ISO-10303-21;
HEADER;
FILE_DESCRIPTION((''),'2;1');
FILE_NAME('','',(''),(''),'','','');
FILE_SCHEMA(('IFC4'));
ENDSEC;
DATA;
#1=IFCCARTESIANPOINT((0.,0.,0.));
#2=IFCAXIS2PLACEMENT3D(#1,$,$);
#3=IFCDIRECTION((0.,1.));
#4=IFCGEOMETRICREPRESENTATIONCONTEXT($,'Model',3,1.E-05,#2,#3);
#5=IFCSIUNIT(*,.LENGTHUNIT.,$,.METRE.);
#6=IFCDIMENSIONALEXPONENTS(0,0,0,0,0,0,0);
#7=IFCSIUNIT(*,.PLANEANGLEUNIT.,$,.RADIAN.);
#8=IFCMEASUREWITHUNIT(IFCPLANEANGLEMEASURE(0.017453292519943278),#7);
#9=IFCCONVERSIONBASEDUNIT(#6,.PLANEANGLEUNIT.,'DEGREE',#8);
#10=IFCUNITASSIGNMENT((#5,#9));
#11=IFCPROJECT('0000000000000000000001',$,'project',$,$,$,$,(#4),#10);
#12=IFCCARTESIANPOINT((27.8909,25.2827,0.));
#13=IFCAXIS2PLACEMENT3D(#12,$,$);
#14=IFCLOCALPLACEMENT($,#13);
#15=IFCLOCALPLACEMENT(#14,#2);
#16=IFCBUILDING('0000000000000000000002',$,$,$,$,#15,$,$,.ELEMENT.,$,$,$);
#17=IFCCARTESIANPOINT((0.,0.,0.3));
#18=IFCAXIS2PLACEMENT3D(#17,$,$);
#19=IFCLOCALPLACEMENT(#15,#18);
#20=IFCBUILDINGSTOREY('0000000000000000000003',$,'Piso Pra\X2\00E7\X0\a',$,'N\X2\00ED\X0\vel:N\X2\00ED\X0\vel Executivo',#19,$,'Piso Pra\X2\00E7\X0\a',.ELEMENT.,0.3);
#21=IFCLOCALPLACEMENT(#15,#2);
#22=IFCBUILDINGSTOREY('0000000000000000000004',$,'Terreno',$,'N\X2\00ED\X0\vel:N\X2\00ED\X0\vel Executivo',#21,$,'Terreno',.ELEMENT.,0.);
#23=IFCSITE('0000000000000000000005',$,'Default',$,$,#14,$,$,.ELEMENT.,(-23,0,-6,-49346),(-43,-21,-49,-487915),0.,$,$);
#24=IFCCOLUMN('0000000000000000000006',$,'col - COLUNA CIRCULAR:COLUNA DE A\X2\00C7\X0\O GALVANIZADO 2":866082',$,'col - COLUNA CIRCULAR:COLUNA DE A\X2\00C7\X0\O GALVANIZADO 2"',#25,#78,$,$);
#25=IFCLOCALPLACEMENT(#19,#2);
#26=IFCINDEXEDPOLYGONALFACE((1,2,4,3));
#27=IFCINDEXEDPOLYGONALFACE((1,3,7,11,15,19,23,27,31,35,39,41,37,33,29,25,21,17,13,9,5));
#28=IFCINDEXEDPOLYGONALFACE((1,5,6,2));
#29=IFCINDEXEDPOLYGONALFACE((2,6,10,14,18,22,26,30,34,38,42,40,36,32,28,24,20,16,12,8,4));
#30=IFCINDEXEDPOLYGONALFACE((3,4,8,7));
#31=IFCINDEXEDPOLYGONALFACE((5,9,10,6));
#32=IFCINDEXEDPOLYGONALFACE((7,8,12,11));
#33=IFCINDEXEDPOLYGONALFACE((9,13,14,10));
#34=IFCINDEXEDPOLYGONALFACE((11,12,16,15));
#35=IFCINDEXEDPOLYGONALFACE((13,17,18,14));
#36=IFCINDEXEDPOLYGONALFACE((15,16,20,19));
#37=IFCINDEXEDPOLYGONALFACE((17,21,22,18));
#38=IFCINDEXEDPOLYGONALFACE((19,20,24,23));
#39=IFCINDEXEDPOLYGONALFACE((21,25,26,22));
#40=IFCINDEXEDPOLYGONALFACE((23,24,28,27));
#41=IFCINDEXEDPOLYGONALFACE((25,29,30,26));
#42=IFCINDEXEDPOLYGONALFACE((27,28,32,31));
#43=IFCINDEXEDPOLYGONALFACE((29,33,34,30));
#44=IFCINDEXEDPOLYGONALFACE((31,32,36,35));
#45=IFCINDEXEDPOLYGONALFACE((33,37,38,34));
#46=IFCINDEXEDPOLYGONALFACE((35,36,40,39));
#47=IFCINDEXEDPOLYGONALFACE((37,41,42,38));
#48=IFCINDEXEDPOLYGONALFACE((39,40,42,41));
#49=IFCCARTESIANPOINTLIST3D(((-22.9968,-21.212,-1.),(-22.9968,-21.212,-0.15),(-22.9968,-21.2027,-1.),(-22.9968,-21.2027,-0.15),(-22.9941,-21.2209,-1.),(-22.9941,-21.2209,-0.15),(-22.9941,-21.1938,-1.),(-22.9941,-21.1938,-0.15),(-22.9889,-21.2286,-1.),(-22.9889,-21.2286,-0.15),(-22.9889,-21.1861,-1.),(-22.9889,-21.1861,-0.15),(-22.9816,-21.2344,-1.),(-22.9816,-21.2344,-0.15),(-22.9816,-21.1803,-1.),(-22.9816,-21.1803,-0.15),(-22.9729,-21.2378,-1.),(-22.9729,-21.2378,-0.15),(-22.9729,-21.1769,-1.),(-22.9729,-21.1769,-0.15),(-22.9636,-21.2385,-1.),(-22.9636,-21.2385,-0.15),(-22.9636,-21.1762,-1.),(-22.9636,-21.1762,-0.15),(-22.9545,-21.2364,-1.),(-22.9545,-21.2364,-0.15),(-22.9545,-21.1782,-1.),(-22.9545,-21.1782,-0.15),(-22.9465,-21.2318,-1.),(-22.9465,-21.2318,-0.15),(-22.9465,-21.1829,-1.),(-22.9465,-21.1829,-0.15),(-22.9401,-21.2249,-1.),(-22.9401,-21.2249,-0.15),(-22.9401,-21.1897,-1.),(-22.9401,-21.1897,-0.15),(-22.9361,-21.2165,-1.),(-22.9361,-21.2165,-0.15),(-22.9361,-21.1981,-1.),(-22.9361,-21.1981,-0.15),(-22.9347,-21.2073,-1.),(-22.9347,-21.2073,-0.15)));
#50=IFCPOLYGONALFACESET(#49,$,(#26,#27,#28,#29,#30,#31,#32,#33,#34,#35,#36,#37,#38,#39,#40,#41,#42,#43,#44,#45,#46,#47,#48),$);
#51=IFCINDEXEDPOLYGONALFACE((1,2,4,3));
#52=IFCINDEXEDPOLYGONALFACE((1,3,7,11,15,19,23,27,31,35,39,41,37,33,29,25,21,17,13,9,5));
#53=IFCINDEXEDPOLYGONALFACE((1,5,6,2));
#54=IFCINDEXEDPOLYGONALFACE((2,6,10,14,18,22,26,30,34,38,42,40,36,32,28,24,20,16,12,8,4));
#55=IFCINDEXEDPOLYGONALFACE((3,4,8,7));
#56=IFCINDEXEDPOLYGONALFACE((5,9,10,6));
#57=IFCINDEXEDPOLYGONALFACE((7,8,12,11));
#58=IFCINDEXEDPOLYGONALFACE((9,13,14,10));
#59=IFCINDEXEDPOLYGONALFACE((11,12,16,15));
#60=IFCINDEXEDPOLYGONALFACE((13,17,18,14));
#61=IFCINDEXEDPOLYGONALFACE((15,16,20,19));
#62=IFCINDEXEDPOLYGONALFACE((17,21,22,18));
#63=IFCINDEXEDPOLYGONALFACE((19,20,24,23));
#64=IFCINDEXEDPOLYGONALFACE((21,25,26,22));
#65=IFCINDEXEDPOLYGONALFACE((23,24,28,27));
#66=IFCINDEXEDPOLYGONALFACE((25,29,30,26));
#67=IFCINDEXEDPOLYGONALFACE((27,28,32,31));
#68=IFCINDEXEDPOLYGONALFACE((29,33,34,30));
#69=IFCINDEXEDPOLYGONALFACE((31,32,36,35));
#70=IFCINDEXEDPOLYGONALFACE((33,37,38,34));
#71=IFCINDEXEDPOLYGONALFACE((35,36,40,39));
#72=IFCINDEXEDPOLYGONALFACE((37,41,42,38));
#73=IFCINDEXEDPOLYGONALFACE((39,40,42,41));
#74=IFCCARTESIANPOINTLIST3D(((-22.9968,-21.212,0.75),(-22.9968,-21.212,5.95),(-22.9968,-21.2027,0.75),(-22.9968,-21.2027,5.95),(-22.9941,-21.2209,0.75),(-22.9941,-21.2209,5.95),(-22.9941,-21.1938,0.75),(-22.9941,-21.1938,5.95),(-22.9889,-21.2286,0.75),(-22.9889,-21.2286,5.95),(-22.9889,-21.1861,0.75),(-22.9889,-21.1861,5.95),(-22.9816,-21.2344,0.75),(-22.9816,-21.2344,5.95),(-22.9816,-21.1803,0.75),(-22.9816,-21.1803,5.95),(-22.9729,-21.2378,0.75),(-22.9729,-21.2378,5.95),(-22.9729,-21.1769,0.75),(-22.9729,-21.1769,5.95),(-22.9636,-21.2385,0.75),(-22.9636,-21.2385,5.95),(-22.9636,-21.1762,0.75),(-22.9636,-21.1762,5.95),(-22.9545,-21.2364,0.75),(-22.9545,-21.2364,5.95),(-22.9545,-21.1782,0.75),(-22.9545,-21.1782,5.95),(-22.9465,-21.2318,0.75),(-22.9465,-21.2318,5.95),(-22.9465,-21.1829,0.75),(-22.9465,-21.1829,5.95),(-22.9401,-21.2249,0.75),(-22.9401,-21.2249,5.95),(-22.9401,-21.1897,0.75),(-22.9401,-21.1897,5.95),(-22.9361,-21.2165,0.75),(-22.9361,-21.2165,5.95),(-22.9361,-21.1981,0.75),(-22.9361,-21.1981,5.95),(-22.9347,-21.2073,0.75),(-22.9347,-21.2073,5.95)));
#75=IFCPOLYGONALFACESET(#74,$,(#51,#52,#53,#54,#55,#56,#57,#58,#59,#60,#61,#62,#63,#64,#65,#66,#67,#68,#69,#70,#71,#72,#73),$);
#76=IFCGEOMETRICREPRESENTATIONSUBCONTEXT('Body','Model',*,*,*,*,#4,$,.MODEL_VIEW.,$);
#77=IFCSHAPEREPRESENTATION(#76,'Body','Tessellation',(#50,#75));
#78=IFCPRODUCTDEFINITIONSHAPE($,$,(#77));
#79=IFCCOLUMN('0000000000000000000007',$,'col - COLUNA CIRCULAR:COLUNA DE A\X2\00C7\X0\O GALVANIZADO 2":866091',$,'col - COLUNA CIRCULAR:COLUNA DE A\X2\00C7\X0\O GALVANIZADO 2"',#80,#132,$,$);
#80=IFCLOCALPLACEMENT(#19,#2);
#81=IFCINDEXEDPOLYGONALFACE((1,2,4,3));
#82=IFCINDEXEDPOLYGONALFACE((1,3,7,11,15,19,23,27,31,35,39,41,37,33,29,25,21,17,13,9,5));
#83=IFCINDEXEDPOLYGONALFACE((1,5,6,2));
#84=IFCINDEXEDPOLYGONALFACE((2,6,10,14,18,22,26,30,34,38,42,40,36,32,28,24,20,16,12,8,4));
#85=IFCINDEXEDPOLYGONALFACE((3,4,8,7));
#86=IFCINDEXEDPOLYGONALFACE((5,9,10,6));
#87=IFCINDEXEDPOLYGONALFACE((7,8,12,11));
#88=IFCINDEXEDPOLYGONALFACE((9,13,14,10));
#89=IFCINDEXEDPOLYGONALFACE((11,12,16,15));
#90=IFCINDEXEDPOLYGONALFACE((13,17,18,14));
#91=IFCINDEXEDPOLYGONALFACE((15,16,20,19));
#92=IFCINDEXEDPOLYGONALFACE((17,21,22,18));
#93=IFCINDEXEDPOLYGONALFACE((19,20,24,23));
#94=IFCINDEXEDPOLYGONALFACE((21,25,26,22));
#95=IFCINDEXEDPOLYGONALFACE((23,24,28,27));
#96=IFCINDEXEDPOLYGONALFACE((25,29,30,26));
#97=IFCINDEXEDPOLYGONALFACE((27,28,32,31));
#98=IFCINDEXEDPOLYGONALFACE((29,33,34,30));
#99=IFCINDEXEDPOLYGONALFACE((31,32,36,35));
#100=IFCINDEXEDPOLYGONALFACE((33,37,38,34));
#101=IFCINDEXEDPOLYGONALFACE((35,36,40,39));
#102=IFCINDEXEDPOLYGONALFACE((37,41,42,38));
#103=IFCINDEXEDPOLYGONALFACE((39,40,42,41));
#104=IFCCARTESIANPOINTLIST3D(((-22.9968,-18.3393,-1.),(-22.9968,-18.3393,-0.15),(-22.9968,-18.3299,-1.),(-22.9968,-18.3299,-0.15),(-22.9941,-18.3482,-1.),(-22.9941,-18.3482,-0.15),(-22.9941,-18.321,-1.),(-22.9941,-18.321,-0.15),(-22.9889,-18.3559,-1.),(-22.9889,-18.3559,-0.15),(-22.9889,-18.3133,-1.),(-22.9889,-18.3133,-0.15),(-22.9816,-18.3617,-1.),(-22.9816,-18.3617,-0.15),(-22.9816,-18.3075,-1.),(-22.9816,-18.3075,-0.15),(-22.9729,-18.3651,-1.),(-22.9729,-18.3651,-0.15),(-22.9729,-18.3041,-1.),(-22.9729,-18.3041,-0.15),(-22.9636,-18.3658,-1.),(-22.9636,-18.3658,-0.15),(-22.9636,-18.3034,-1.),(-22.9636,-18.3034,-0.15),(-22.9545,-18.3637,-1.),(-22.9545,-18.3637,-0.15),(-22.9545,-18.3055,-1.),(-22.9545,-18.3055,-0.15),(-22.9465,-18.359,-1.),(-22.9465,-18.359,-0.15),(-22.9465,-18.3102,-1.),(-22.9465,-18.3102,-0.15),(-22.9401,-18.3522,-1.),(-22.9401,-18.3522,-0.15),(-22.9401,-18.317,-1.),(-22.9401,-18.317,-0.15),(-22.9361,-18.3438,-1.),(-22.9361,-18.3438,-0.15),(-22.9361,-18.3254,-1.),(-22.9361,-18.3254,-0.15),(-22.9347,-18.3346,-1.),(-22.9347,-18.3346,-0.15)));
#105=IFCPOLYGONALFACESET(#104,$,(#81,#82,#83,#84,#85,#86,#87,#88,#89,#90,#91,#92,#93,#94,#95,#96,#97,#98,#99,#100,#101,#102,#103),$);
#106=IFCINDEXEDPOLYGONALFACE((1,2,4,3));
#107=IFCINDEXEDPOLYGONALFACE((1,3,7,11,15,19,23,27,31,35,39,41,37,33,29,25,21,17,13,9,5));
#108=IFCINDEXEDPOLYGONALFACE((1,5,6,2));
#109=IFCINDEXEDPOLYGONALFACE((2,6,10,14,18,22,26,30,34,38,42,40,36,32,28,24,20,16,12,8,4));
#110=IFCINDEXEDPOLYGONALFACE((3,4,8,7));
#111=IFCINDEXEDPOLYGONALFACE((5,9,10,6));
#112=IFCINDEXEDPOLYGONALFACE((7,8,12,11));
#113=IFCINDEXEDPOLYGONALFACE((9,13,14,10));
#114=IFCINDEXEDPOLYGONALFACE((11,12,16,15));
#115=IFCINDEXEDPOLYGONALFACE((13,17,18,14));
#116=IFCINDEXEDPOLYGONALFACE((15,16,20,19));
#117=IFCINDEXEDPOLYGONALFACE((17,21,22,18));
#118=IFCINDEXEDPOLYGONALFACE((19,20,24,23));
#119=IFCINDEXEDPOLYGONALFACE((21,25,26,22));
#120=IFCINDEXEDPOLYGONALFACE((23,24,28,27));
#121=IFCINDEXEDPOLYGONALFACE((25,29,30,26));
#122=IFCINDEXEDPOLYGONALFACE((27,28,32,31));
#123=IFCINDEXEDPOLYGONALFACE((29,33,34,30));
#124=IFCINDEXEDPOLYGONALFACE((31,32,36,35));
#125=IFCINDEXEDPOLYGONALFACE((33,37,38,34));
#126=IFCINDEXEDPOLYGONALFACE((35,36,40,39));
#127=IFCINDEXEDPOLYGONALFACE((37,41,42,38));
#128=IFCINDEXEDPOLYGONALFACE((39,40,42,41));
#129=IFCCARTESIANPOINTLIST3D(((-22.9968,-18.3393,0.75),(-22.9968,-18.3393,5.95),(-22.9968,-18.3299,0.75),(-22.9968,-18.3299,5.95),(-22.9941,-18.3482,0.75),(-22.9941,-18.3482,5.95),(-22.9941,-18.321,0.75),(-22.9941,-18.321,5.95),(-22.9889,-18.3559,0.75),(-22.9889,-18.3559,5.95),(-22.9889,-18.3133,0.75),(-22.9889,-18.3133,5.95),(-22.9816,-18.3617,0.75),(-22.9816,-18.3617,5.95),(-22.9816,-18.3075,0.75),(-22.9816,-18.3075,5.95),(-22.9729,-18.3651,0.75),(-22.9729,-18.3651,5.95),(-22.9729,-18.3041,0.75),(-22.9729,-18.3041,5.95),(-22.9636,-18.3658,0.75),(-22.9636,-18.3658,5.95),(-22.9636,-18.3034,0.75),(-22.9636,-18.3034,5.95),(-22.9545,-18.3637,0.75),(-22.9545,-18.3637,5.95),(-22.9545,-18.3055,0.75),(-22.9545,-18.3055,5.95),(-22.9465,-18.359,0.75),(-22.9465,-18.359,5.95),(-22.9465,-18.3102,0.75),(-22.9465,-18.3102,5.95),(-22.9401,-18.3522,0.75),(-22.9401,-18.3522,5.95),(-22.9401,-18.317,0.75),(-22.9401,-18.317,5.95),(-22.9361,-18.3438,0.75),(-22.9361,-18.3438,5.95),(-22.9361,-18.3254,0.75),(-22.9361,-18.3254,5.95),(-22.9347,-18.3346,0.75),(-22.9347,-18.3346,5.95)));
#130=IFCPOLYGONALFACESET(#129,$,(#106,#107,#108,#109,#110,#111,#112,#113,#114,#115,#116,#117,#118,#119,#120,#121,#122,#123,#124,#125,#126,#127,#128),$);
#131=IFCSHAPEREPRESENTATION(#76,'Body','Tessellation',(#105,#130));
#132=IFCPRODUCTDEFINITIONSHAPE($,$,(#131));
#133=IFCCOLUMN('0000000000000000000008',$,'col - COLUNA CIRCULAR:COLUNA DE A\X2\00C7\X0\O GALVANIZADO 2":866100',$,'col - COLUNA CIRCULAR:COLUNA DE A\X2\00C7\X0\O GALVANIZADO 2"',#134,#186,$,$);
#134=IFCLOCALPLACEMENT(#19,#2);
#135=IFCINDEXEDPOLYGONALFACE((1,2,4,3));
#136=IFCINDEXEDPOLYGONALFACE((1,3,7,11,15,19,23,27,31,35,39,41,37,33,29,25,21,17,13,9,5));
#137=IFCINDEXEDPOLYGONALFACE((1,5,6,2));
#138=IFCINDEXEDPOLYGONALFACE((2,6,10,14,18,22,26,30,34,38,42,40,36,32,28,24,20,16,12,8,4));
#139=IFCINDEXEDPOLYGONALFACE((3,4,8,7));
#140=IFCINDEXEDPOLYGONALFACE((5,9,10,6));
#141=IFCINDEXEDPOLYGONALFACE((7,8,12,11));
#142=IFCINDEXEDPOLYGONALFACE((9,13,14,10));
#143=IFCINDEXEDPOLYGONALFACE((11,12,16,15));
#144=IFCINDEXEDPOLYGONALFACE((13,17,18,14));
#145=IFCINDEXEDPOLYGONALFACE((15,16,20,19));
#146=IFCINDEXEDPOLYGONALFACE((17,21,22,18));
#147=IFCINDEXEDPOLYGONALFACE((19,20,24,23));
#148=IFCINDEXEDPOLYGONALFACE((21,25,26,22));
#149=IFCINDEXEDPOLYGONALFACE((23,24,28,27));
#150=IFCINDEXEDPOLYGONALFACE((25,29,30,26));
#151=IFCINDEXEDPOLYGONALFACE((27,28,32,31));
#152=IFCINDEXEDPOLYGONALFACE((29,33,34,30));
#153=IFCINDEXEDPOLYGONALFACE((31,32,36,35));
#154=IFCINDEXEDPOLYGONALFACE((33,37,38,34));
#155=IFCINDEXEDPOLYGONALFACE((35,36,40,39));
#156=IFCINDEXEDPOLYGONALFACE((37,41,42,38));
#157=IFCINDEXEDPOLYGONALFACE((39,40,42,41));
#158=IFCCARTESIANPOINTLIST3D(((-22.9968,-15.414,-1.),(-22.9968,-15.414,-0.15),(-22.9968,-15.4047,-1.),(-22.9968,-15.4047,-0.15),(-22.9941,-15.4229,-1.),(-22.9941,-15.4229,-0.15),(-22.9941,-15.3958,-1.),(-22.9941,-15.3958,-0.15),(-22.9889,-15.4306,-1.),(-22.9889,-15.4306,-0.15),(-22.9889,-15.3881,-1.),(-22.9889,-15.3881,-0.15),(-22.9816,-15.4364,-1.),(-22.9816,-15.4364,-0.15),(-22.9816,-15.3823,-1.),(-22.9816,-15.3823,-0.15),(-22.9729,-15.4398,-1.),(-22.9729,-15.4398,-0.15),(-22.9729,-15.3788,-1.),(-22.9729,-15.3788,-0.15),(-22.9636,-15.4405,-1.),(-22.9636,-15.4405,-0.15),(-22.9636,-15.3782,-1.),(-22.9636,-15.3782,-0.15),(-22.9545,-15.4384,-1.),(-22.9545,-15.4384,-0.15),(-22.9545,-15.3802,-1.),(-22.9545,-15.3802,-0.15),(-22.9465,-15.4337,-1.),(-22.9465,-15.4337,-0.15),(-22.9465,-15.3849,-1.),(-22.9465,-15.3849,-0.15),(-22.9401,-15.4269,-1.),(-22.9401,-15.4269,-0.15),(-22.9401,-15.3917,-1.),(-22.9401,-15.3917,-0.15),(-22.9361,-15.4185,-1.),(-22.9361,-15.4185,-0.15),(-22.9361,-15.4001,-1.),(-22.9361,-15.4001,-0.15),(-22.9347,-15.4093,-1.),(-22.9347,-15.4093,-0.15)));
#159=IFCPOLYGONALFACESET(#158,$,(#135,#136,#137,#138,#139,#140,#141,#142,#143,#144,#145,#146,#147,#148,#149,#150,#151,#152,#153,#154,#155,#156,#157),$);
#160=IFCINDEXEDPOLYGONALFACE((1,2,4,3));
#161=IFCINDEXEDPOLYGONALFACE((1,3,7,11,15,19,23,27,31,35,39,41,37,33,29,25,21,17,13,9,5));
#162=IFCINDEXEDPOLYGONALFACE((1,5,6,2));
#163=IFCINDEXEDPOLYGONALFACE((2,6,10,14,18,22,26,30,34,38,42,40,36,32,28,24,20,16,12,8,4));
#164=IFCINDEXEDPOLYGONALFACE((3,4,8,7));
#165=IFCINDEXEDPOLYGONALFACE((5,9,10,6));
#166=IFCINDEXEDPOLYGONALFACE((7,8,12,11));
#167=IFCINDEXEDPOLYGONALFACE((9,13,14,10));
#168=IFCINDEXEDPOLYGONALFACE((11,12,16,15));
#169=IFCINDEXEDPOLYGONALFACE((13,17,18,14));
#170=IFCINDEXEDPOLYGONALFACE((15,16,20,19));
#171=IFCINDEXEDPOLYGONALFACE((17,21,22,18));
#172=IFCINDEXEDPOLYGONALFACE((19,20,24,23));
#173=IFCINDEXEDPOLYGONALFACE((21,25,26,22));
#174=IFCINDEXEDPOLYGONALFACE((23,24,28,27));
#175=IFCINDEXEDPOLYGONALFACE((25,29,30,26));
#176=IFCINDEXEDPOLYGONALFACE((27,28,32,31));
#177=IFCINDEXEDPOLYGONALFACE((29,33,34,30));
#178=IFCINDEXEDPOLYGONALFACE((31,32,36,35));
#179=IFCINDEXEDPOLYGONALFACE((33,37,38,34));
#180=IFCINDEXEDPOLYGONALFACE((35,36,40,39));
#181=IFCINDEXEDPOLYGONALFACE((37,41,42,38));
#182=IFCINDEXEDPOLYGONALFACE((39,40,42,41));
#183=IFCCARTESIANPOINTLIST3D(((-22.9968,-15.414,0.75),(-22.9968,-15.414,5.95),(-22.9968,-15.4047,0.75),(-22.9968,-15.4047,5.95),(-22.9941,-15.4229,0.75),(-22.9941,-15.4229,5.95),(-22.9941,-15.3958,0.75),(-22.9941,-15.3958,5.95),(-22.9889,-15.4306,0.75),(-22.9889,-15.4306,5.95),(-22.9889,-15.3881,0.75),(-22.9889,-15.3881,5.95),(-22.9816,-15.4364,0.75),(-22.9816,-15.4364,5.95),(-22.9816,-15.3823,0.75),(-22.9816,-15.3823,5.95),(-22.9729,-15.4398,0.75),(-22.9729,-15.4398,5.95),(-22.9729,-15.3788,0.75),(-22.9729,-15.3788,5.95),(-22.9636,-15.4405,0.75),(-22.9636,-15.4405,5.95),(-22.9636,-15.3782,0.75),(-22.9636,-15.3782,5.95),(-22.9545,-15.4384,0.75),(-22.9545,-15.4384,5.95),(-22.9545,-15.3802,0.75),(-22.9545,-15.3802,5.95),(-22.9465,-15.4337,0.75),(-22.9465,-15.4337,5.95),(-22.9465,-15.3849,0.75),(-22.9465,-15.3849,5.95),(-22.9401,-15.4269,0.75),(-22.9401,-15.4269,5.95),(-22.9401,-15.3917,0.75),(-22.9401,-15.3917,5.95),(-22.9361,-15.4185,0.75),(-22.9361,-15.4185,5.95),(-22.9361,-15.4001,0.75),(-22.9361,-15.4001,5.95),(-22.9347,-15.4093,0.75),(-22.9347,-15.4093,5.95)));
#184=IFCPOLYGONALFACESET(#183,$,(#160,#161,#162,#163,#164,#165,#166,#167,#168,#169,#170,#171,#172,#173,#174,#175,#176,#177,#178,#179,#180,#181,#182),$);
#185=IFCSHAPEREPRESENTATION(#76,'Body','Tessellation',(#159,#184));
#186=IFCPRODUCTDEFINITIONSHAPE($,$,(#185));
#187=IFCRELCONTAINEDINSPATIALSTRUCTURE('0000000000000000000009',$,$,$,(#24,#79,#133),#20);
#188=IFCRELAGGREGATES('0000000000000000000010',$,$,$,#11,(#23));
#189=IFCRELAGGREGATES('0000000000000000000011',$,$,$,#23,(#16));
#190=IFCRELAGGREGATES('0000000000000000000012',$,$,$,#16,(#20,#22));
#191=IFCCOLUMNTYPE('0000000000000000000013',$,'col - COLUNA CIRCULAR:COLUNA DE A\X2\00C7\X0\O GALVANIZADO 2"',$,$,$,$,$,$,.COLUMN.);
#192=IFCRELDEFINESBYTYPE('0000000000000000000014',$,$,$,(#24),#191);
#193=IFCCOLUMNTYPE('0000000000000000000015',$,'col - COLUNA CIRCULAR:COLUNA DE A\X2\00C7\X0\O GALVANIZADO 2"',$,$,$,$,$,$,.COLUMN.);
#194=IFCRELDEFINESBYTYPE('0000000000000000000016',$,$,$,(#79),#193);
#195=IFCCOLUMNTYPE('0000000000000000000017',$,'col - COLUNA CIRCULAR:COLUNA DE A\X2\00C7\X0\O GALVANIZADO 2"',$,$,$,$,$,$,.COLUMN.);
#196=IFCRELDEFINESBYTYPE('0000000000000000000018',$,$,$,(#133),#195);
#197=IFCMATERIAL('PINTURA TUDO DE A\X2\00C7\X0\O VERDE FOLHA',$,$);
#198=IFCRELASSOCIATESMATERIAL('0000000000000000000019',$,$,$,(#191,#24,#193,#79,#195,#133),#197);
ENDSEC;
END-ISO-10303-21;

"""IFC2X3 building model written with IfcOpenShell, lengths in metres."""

from ifc_helpers import new_model, entity, si_unit, converted_unit, direction, frame, origin, origin_2d_with_axis, place, context, subcontext, project, spatial, circle, extrude, source, transform, mapped, material, type_object, type_shapes, element, save


model = new_model("IFC2X3")

# Units and contexts
model_context = context("Model", 3, precision=1e-05, world=origin(), true_north=direction((0.0, 1.0)))
body_context = subcontext(model_context, "Body", "Model", "MODEL_VIEW")
ifc_project = project(units=[si_unit("LENGTHUNIT", "METRE"), converted_unit("PLANEANGLEUNIT", "DEGREE", entity("IfcPlaneAngleMeasure", 0.017453292519943278), si_unit("PLANEANGLEUNIT", "RADIAN"), dimensions=[0, 0, 0, 0, 0, 0, 0])], contexts=[model_context])

# Site, building, storey
site_placement = place(None, frame((27.8909, 25.2827, 0.0)))
site = spatial("IfcSite", under=ifc_project, at=site_placement, Name="Default", CompositionType="ELEMENT", RefLatitude=(-23, 0, -6, -49346), RefLongitude=(-43, -21, -49, -487915), RefElevation=0.0)
building_placement = place(site_placement, origin())
building = spatial("IfcBuilding", under=site, at=building_placement, CompositionType="ELEMENT")
storey_1_placement = place(building_placement, frame((0.0, 0.0, 0.3)))
storey_1 = spatial("IfcBuildingStorey", under=building, at=storey_1_placement, Name="Piso Praça", ObjectType="Nível:Nível Executivo", LongName="Piso Praça", CompositionType="ELEMENT", Elevation=0.3)

# Columns
ifc_material_1 = material(Name="PINTURA TUDO DE AÇO VERDE FOLHA")
column_type_1 = type_object("IfcColumnType", Name="col - COLUNA CIRCULAR:COLUNA DE AÇO GALVANIZADO 2\"", PredefinedType="COLUMN", material=ifc_material_1)
shared_shape_1 = source(origin(), body_context, "Body", "SweptSolid", [
    extrude(circle(Radius=0.0312, at=origin_2d_with_axis()), frame((-22.9659, -21.2073, -0.7)), (0.0, 0.0, 1.0), 0.85),
    extrude(circle(Radius=0.0312, at=origin_2d_with_axis()), frame((-22.9659, -21.2073, 1.05)), (0.0, 0.0, 1.0), 5.2),
])
type_shapes(column_type_1, [shared_shape_1])
column_1_placement = place(storey_1_placement, frame((0.0, 0.0, -0.3)))
element("IfcColumn", 1, at=column_1_placement, inside=storey_1, type_object=column_type_1, material=ifc_material_1, Name="col - COLUNA CIRCULAR:COLUNA DE AÇO GALVANIZADO 2\":866082", ObjectType="col - COLUNA CIRCULAR:COLUNA DE AÇO GALVANIZADO 2\"", context=body_context, shape_type="MappedRepresentation", body=[
    mapped(shared_shape_1, transform((0.0, 0.0, 0.0), scale=1.0)),
])
column_type_2 = type_object("IfcColumnType", Name="col - COLUNA CIRCULAR:COLUNA DE AÇO GALVANIZADO 2\"", PredefinedType="COLUMN", material=ifc_material_1)
shared_shape_2 = source(origin(), body_context, "Body", "SweptSolid", [
    extrude(circle(Radius=0.0312, at=origin_2d_with_axis()), frame((-22.9659, -18.3346, -0.7)), (0.0, 0.0, 1.0), 0.85),
    extrude(circle(Radius=0.0312, at=origin_2d_with_axis()), frame((-22.9659, -18.3346, 1.05)), (0.0, 0.0, 1.0), 5.2),
])
type_shapes(column_type_2, [shared_shape_2])
column_2_placement = place(storey_1_placement, frame((0.0, 0.0, -0.3)))
element("IfcColumn", 2, at=column_2_placement, inside=storey_1, type_object=column_type_2, material=ifc_material_1, Name="col - COLUNA CIRCULAR:COLUNA DE AÇO GALVANIZADO 2\":866091", ObjectType="col - COLUNA CIRCULAR:COLUNA DE AÇO GALVANIZADO 2\"", context=body_context, shape_type="MappedRepresentation", body=[
    mapped(shared_shape_2, transform((0.0, 0.0, 0.0), scale=1.0)),
])
column_type_3 = type_object("IfcColumnType", Name="col - COLUNA CIRCULAR:COLUNA DE AÇO GALVANIZADO 2\"", PredefinedType="COLUMN", material=ifc_material_1)
shared_shape_3 = source(origin(), body_context, "Body", "SweptSolid", [
    extrude(circle(Radius=0.0312, at=origin_2d_with_axis()), frame((-22.9659, -15.4093, -0.7)), (0.0, 0.0, 1.0), 0.85),
    extrude(circle(Radius=0.0312, at=origin_2d_with_axis()), frame((-22.9659, -15.4093, 1.05)), (0.0, 0.0, 1.0), 5.2),
])
type_shapes(column_type_3, [shared_shape_3])
column_3_placement = place(storey_1_placement, frame((0.0, 0.0, -0.3)))
element("IfcColumn", 3, at=column_3_placement, inside=storey_1, type_object=column_type_3, material=ifc_material_1, Name="col - COLUNA CIRCULAR:COLUNA DE AÇO GALVANIZADO 2\":866100", ObjectType="col - COLUNA CIRCULAR:COLUNA DE AÇO GALVANIZADO 2\"", context=body_context, shape_type="MappedRepresentation", body=[
    mapped(shared_shape_3, transform((0.0, 0.0, 0.0), scale=1.0)),
])

# Shared definitions
storey_2_placement = place(building_placement, origin())
storey_2 = spatial("IfcBuildingStorey", under=building, at=storey_2_placement, Name="Terreno", ObjectType="Nível:Nível Executivo", LongName="Terreno", CompositionType="ELEMENT", Elevation=0.0)

save(model, "model.ifc")
